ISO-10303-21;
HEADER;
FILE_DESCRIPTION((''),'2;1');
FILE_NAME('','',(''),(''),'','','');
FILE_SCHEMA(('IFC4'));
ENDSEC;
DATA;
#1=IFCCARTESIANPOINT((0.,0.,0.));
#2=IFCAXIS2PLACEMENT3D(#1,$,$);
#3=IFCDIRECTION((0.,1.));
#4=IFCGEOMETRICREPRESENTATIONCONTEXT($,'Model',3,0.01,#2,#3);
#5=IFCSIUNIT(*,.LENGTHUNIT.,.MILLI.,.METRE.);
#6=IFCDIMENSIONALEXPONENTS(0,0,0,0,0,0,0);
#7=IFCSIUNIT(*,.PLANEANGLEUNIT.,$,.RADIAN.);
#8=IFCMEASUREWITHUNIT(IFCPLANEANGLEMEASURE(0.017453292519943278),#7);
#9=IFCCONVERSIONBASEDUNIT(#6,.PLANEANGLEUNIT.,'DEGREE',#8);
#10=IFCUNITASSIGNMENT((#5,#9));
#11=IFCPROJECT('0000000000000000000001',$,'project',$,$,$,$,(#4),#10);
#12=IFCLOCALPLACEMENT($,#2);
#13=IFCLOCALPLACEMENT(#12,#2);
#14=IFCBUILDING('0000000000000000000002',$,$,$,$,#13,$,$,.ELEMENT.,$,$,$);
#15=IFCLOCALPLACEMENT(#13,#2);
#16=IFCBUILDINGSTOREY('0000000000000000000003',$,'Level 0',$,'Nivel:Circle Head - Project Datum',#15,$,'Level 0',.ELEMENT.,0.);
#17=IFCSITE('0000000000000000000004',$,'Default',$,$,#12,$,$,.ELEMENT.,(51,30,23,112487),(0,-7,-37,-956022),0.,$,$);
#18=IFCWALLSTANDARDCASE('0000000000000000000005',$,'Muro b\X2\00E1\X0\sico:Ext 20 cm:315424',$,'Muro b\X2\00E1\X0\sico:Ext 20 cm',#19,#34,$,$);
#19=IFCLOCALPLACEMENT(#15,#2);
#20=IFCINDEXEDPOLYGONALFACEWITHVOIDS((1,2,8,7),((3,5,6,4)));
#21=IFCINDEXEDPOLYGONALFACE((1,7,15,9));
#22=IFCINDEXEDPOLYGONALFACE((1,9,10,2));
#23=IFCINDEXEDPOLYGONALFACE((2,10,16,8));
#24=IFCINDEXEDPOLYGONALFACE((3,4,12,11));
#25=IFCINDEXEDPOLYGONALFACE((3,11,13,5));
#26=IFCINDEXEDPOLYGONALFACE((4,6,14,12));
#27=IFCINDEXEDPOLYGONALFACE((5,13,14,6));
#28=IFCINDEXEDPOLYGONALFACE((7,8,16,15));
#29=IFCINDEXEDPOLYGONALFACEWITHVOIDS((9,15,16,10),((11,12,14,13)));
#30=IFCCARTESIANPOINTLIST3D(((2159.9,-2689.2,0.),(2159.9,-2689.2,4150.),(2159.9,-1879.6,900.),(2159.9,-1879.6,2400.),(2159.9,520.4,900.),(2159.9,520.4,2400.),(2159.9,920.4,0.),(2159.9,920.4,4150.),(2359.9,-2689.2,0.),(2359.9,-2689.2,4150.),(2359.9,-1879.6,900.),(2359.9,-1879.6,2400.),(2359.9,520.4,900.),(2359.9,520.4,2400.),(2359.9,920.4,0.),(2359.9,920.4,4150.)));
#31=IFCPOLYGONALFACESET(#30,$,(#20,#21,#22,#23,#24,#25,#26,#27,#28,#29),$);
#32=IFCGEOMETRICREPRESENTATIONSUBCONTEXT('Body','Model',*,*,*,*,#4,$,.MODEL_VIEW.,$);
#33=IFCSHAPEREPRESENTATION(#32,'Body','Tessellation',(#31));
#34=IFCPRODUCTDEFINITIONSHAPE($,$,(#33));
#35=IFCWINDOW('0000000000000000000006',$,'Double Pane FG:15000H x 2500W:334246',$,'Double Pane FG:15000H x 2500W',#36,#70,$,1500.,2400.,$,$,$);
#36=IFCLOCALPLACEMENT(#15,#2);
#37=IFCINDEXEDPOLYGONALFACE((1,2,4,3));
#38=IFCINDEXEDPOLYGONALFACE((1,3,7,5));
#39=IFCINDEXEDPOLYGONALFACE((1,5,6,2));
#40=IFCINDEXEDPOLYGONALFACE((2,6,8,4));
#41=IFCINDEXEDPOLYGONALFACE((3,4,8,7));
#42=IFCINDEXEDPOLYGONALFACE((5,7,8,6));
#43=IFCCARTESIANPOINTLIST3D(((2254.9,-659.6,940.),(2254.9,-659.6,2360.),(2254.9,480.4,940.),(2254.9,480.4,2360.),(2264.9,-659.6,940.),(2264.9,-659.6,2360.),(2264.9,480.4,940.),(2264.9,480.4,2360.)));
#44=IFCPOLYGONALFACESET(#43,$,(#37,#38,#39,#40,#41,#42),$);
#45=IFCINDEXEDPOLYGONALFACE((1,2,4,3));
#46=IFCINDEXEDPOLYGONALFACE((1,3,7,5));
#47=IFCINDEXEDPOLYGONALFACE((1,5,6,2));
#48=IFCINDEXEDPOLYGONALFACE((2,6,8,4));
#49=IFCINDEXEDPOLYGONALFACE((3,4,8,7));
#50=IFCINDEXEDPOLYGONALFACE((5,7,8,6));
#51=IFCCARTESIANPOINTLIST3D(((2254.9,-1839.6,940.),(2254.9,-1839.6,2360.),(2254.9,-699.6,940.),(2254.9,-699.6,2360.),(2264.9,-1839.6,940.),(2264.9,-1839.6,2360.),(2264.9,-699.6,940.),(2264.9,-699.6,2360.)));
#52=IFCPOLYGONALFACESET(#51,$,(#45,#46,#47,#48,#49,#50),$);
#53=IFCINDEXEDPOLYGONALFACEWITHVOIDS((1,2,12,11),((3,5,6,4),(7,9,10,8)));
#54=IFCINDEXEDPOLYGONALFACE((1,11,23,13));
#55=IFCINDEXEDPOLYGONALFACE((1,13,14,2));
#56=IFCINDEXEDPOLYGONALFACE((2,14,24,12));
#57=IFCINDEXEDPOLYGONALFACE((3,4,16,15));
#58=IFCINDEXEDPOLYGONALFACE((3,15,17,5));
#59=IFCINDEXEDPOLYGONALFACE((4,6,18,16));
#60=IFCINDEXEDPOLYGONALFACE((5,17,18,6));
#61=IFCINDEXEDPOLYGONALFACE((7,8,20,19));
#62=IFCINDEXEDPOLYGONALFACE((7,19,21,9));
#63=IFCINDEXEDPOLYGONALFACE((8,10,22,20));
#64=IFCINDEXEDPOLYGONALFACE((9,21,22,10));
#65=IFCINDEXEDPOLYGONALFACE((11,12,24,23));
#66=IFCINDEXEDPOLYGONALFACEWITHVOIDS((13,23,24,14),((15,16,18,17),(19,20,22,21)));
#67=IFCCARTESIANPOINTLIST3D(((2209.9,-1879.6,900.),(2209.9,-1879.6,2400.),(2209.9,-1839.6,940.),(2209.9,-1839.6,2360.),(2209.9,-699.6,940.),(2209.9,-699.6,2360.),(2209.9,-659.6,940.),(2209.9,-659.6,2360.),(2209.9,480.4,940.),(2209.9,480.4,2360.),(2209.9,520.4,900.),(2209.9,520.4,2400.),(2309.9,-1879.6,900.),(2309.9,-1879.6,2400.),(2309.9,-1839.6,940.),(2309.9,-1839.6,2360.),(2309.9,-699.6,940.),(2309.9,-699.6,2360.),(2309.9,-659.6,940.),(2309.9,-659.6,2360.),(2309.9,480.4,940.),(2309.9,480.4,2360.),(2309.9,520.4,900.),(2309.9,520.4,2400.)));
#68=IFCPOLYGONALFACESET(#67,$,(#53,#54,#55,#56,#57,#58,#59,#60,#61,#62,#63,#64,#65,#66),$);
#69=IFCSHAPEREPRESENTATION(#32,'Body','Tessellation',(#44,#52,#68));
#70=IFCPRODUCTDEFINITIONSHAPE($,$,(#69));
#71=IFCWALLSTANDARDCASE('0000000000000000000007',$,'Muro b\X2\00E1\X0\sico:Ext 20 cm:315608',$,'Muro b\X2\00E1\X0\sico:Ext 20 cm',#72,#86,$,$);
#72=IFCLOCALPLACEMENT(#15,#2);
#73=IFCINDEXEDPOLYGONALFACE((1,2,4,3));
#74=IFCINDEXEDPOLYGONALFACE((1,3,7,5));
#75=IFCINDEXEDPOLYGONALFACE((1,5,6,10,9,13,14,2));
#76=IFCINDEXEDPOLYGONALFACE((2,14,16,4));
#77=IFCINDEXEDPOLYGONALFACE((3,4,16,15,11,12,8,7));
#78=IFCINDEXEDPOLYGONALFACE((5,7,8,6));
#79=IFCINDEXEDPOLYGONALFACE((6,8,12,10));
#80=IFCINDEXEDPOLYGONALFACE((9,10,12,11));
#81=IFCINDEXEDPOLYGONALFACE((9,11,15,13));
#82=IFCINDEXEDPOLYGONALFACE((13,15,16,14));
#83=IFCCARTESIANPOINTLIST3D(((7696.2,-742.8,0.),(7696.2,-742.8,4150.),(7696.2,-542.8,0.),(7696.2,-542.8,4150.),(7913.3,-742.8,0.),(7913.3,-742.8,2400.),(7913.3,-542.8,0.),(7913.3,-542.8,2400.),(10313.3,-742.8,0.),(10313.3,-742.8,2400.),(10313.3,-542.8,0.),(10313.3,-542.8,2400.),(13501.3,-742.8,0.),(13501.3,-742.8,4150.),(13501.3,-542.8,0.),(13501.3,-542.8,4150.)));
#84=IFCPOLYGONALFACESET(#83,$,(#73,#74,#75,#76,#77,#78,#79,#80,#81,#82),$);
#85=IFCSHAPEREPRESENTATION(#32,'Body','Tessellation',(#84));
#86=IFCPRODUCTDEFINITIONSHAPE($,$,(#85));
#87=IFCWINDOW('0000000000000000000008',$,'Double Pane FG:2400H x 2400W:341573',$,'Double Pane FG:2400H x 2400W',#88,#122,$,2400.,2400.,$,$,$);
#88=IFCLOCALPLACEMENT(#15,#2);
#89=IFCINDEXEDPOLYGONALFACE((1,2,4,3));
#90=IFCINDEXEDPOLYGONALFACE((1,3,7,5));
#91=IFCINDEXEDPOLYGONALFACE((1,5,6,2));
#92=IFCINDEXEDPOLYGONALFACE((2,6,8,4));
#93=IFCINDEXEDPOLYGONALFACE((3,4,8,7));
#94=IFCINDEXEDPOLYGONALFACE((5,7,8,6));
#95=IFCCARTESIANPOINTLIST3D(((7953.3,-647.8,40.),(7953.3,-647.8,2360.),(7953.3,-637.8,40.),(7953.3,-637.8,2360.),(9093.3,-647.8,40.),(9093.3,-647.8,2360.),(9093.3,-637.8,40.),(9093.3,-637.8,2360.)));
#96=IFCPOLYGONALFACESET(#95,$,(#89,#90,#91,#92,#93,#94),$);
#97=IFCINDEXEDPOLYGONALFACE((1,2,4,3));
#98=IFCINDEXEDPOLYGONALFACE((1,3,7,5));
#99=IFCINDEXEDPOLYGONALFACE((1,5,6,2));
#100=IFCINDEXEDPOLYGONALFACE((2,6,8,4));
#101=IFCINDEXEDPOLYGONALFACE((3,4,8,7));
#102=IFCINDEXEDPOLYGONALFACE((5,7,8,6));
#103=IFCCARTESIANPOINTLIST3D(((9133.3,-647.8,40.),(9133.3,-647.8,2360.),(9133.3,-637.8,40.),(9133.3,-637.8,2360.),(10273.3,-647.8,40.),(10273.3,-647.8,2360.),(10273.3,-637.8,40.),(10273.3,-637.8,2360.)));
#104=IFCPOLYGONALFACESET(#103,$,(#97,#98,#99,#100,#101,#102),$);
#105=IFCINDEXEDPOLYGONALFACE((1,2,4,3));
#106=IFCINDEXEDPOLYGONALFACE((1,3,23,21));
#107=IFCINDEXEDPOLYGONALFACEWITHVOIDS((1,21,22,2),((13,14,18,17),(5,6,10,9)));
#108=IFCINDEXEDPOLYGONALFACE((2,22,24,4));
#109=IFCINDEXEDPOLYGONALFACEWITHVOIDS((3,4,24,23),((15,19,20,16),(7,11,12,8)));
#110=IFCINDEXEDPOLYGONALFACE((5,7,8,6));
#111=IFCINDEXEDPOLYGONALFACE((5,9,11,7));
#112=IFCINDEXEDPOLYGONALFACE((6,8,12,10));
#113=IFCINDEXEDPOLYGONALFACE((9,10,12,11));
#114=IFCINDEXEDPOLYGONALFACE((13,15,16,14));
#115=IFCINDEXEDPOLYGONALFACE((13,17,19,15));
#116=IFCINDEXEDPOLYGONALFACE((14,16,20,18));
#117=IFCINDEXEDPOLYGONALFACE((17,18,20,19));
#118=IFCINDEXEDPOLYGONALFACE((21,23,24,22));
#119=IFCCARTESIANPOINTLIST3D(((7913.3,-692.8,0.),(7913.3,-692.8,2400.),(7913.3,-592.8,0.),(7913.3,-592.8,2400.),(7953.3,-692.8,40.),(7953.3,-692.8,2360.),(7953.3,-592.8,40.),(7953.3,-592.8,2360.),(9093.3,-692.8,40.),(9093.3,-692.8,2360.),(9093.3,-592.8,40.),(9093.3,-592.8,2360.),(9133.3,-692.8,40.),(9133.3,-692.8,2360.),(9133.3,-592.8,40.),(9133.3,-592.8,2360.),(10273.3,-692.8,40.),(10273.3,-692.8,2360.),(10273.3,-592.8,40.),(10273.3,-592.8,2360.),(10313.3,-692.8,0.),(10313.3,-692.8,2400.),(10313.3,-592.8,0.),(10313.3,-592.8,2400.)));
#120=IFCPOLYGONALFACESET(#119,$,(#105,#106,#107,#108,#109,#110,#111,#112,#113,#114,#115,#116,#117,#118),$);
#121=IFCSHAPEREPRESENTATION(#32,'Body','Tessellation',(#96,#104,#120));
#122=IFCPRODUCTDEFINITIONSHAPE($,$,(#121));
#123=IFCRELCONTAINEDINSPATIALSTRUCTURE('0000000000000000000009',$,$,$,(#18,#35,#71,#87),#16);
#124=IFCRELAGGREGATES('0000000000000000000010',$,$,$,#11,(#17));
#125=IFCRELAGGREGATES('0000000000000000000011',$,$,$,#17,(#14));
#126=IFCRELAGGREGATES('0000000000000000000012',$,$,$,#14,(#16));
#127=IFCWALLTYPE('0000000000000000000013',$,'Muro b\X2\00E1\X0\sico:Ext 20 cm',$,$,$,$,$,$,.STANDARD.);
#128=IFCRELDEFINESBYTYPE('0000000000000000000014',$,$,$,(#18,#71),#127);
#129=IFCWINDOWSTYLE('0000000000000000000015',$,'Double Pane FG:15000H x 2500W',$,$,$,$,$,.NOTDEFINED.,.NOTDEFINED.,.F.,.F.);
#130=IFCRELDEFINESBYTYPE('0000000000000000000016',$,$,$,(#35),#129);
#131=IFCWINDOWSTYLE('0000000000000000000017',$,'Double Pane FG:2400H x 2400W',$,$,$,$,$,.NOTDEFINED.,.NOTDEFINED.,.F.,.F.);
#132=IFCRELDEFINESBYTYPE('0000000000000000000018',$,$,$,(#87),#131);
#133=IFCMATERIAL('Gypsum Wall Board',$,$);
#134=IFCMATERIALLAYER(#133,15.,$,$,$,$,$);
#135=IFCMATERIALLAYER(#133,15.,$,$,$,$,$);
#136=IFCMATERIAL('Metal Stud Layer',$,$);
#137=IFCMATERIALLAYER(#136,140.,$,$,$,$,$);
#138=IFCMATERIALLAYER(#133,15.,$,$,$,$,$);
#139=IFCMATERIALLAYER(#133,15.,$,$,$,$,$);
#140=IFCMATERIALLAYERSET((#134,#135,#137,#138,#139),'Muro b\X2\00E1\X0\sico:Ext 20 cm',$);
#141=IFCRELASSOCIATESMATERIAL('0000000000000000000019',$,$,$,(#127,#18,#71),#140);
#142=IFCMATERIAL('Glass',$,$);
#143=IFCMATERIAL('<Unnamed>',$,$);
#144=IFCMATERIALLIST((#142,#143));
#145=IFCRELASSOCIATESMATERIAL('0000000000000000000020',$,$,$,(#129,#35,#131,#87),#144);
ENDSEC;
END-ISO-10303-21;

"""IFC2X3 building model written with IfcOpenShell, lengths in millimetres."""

from ifc_helpers import new_model, entity, si_unit, converted_unit, direction, frame, frame_2d, origin, origin_2d_with_axis, place, context, subcontext, project, spatial, polyline, rectangle, outline, extrude, source, transform, mapped, material, material_list, layer, layer_set, layer_usage, type_object, type_shapes, element, fill, save


model = new_model("IFC2X3")

# Units and contexts
model_context = context("Model", 3, precision=0.01, world=origin(), true_north=direction((0.0, 1.0)))
body_context = subcontext(model_context, "Body", "Model", "MODEL_VIEW")
ifc_project = project(units=[si_unit("LENGTHUNIT", "METRE", prefix="MILLI"), converted_unit("PLANEANGLEUNIT", "DEGREE", entity("IfcPlaneAngleMeasure", 0.017453292519943278), si_unit("PLANEANGLEUNIT", "RADIAN"), dimensions=[0, 0, 0, 0, 0, 0, 0])], contexts=[model_context])

# Site, building, storey
site_placement = place(None, origin())
site = spatial("IfcSite", under=ifc_project, at=site_placement, Name="Default", CompositionType="ELEMENT", RefLatitude=(51, 30, 23, 112487), RefLongitude=(0, -7, -37, -956022), RefElevation=0.0)
building_placement = place(site_placement, origin())
building = spatial("IfcBuilding", under=site, at=building_placement, CompositionType="ELEMENT")
storey_placement = place(building_placement, origin())
storey = spatial("IfcBuildingStorey", under=building, at=storey_placement, Name="Level 0", ObjectType="Nivel:Circle Head - Project Datum", LongName="Level 0", CompositionType="ELEMENT", Elevation=0.0)

# Shared definitions
ifc_material_1 = material(Name="Gypsum Wall Board")
ifc_layer_1 = layer(ifc_material_1, 15.0)
ifc_layer_2 = layer(ifc_material_1, 15.0)
ifc_material_2 = material(Name="Metal Stud Layer")
ifc_layer_3 = layer(ifc_material_2, 140.0)
ifc_layer_4 = layer(ifc_material_1, 15.0)
ifc_layer_5 = layer(ifc_material_1, 15.0)
ifc_layer_set_1 = layer_set([ifc_layer_1, ifc_layer_2, ifc_layer_3, ifc_layer_4, ifc_layer_5], Name="Muro básico:Ext 20 cm")
wall_type_1 = type_object("IfcWallType", Name="Muro básico:Ext 20 cm", PredefinedType="STANDARD", material=ifc_layer_set_1)
ifc_material_3 = material(Name="<Unnamed>")
ifc_material_4 = material(Name="Glass")

# Walls, openings, windows
ifc_layer_usage_1 = layer_usage(ifc_layer_set_1, "AXIS2", "NEGATIVE", 100.0)
wall_1_placement = place(storey_placement, frame((2259.9, 920.4, 0.0), z_axis=(0.0, 0.0, 1.0), x_axis=(0.0, -1.0, 0.0)))
wall_1 = element("IfcWallStandardCase", 1, at=wall_1_placement, inside=storey, type_object=wall_type_1, material=ifc_layer_usage_1, Name="Muro básico:Ext 20 cm:315424", ObjectType="Muro básico:Ext 20 cm", context=body_context, shape_type="SweptSolid", body=[
    extrude(rectangle(XDim=3609.6, YDim=200.0, at=frame_2d((1804.8, 0.0), x_axis=(-1.0, 0.0))), origin(), (0.0, 0.0, 1.0), 4150.0),
])
opening_1_placement = place(wall_1_placement, frame((2800.0, 100.0, 900.0)))
opening_1 = element("IfcOpeningElement", 2, at=opening_1_placement, cuts=wall_1, ObjectType="Opening", context=body_context, shape_type="SweptSolid", body=[
    extrude(rectangle(XDim=1500.0, YDim=2400.0, at=frame_2d((750.0, 1200.0), x_axis=(1.0, 0.0))), frame((0.0, 0.0, 0.0), z_axis=(0.0, -1.0, 0.0), x_axis=(0.0, 0.0, 1.0)), (0.0, 0.0, 1.0), 200.0),
])
ifc_material_list_1 = material_list([ifc_material_4, ifc_material_3])
window_style_1 = type_object("IfcWindowStyle", Name="Double Pane FG:15000H x 2500W", ConstructionType="NOTDEFINED", OperationType="NOTDEFINED", ParameterTakesPrecedence=False, Sizeable=False, material=ifc_material_list_1)
shared_shape_1 = source(origin(), body_context, "Body", "SweptSolid", [
    extrude(rectangle(XDim=10.0, YDim=1140.0, at=origin_2d_with_axis()), frame((1790.0, 100.0, 40.0), z_axis=(0.0, 0.0, 1.0), x_axis=(0.0, 1.0, 0.0)), (0.0, 0.0, 1.0), 1420.0),
    extrude(rectangle(XDim=10.0, YDim=1140.0, at=origin_2d_with_axis()), frame((610.0, 100.0, 40.0), z_axis=(0.0, 0.0, 1.0), x_axis=(0.0, 1.0, 0.0)), (0.0, 0.0, 1.0), 1420.0),
    extrude(outline(polyline([(-750.0, -1200.0), (750.0, -1200.0), (750.0, 1200.0), (-750.0, 1200.0), (-750.0, -1200.0)]), holes=[polyline([(710.0, -20.0), (710.0, -1160.0), (-710.0, -1160.0), (-710.0, -20.0), (710.0, -20.0)]), polyline([(-710.0, 20.0), (-710.0, 1160.0), (710.0, 1160.0), (710.0, 20.0), (-710.0, 20.0)])]), frame((1200.0, 50.0, 750.0), z_axis=(0.0, 1.0, 0.0), x_axis=(0.0, 0.0, -1.0)), (0.0, 0.0, 1.0), 100.0),
])
type_shapes(window_style_1, [shared_shape_1])
window_1_placement = place(opening_1_placement, frame((0.0, 0.0, 0.0), z_axis=(0.0, 0.0, 1.0), x_axis=(-1.0, 0.0, 0.0)))
window_1 = element("IfcWindow", 3, at=window_1_placement, inside=storey, type_object=window_style_1, material=ifc_material_list_1, Name="Double Pane FG:15000H x 2500W:334246", ObjectType="Double Pane FG:15000H x 2500W", OverallHeight=1500.0, OverallWidth=2400.0, context=body_context, shape_type="MappedRepresentation", body=[
    mapped(shared_shape_1, transform((0.0, 0.0, 0.0), scale=1.0)),
])
fill(opening_1, window_1)
ifc_layer_usage_2 = layer_usage(ifc_layer_set_1, "AXIS2", "NEGATIVE", 100.0)
wall_2_placement = place(storey_placement, frame((7696.2, -642.8, 0.0)))
wall_2 = element("IfcWallStandardCase", 4, at=wall_2_placement, inside=storey, type_object=wall_type_1, material=ifc_layer_usage_2, Name="Muro básico:Ext 20 cm:315608", ObjectType="Muro básico:Ext 20 cm", context=body_context, shape_type="SweptSolid", body=[
    extrude(rectangle(XDim=5805.1, YDim=200.0, at=frame_2d((2902.6, 0.0), x_axis=(-1.0, 0.0))), origin(), (0.0, 0.0, 1.0), 4150.0),
])
opening_2_placement = place(wall_2_placement, frame((2617.0, 100.0, 0.0)))
opening_2 = element("IfcOpeningElement", 5, at=opening_2_placement, cuts=wall_2, ObjectType="Opening", context=body_context, shape_type="SweptSolid", body=[
    extrude(rectangle(XDim=2400.0, YDim=2400.0, at=frame_2d((1200.0, 1200.0), x_axis=(1.0, 0.0))), frame((0.0, 0.0, 0.0), z_axis=(0.0, -1.0, 0.0), x_axis=(0.0, 0.0, 1.0)), (0.0, 0.0, 1.0), 200.0),
])
window_style_2 = type_object("IfcWindowStyle", Name="Double Pane FG:2400H x 2400W", ConstructionType="NOTDEFINED", OperationType="NOTDEFINED", ParameterTakesPrecedence=False, Sizeable=False, material=ifc_material_list_1)
shared_shape_2 = source(origin(), body_context, "Body", "SweptSolid", [
    extrude(rectangle(XDim=10.0, YDim=1140.0, at=origin_2d_with_axis()), frame((1790.0, 100.0, 40.0), z_axis=(0.0, 0.0, 1.0), x_axis=(0.0, 1.0, 0.0)), (0.0, 0.0, 1.0), 2320.0),
    extrude(rectangle(XDim=10.0, YDim=1140.0, at=origin_2d_with_axis()), frame((610.0, 100.0, 40.0), z_axis=(0.0, 0.0, 1.0), x_axis=(0.0, 1.0, 0.0)), (0.0, 0.0, 1.0), 2320.0),
    extrude(outline(polyline([(-1200.0, -1200.0), (1200.0, -1200.0), (1200.0, 1200.0), (-1200.0, 1200.0), (-1200.0, -1200.0)]), holes=[polyline([(1160.0, -20.0), (1160.0, -1160.0), (-1160.0, -1160.0), (-1160.0, -20.0), (1160.0, -20.0)]), polyline([(-1160.0, 20.0), (-1160.0, 1160.0), (1160.0, 1160.0), (1160.0, 20.0), (-1160.0, 20.0)])]), frame((1200.0, 50.0, 1200.0), z_axis=(0.0, 1.0, 0.0), x_axis=(0.0, 0.0, -1.0)), (0.0, 0.0, 1.0), 100.0),
])
type_shapes(window_style_2, [shared_shape_2])
window_2_placement = place(opening_2_placement, frame((0.0, 0.0, 0.0), z_axis=(0.0, 0.0, 1.0), x_axis=(-1.0, 0.0, 0.0)))
window_2 = element("IfcWindow", 6, at=window_2_placement, inside=storey, type_object=window_style_2, material=ifc_material_list_1, Name="Double Pane FG:2400H x 2400W:341573", ObjectType="Double Pane FG:2400H x 2400W", OverallHeight=2400.0, OverallWidth=2400.0, context=body_context, shape_type="MappedRepresentation", body=[
    mapped(shared_shape_2, transform((0.0, 0.0, 0.0), scale=1.0)),
])
fill(opening_2, window_2)

save(model, "model.ifc")
